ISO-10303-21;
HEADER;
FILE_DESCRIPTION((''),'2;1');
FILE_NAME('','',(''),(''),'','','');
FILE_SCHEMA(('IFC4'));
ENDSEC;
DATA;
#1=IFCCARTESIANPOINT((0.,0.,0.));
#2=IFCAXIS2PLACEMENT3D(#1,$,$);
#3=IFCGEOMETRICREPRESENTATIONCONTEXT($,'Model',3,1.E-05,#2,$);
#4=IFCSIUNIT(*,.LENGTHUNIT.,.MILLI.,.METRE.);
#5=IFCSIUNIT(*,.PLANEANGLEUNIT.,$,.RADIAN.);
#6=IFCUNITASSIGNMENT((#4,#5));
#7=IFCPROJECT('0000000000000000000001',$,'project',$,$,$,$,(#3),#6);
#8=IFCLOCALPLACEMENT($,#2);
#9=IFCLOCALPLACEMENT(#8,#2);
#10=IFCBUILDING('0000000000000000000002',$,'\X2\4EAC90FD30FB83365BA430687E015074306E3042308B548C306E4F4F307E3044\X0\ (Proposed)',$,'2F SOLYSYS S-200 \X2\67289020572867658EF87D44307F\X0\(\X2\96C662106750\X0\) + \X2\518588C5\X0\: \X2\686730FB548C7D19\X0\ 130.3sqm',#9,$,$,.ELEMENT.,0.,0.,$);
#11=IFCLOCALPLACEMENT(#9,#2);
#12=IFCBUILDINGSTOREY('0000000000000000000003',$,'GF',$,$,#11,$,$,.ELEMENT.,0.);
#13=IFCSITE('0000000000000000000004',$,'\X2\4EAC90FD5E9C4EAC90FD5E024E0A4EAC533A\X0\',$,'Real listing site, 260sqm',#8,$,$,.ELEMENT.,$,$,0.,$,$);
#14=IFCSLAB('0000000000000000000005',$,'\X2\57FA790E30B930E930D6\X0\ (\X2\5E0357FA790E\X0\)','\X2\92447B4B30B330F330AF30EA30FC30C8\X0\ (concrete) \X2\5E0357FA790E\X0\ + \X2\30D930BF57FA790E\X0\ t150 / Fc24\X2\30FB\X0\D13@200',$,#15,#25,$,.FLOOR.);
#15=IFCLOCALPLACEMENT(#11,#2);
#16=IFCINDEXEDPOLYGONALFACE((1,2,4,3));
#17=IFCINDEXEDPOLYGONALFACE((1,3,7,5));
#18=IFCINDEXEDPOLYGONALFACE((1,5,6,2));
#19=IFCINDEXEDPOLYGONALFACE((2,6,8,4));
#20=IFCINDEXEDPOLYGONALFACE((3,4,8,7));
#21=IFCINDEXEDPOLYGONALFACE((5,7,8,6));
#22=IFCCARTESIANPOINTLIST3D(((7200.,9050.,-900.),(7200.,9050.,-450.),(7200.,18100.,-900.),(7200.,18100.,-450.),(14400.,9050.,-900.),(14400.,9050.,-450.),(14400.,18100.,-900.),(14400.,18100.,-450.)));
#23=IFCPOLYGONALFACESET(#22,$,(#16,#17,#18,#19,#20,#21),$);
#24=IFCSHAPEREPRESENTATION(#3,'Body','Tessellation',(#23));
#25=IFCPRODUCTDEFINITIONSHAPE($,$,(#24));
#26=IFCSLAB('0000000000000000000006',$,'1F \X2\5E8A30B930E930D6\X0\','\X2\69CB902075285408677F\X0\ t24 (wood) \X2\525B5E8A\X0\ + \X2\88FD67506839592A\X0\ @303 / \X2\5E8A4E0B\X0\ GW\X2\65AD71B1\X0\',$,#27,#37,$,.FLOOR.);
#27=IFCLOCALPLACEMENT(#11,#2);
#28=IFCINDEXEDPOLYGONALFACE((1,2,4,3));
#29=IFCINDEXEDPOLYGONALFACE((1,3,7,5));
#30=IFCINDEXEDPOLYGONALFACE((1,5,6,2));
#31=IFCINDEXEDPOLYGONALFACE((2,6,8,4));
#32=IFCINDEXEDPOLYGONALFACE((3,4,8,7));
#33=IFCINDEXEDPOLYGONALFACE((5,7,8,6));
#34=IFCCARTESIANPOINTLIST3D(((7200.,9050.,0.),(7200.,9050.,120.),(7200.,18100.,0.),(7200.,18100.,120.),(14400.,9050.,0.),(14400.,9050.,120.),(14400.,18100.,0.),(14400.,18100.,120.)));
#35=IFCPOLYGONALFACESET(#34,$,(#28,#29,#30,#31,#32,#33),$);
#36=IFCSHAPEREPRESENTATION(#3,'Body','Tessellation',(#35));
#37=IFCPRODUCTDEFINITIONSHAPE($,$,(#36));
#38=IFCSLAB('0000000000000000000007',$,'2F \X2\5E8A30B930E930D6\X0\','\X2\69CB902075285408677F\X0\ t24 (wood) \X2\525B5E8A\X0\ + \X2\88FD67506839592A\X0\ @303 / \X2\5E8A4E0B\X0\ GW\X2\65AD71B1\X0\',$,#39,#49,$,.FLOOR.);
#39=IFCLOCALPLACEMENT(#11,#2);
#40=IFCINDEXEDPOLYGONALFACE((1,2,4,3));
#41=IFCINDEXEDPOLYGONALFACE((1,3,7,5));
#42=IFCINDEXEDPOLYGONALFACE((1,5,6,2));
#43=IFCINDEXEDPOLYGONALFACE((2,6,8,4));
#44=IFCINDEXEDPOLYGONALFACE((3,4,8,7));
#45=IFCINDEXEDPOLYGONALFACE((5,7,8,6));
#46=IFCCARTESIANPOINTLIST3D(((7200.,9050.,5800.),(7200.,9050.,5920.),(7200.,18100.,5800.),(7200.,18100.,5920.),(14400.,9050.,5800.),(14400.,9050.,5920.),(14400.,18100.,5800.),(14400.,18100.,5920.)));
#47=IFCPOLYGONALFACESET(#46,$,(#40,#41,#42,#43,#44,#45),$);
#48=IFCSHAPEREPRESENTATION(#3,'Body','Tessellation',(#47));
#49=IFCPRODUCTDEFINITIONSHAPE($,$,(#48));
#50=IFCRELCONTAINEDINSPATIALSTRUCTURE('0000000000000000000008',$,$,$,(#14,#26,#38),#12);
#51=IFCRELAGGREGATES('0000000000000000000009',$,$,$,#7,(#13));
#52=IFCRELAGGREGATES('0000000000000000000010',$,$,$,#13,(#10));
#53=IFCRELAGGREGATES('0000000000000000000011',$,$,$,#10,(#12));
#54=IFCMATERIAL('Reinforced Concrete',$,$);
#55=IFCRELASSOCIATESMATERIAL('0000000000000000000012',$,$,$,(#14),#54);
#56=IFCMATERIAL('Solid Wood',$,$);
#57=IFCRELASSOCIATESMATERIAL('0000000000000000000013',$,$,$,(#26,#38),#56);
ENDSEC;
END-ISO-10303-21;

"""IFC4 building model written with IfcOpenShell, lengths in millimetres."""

from ifc_helpers import new_model, si_unit, frame, frame_2d, origin, place, context, project, spatial, rectangle, extrude, material, element, save


model = new_model("IFC4")

# Units and contexts
model_context = context("Model", 3, precision=1e-05, world=origin())
ifc_project = project(units=[si_unit("LENGTHUNIT", "METRE", prefix="MILLI"), si_unit("PLANEANGLEUNIT", "RADIAN")], contexts=[model_context])

# Site, building, storey
site_placement = place(None, origin())
site = spatial("IfcSite", under=ifc_project, at=site_placement, Name="京都府京都市上京区", ObjectType="Real listing site, 260sqm", CompositionType="ELEMENT", RefElevation=0.0)
building_placement = place(site_placement, origin())
building = spatial("IfcBuilding", under=site, at=building_placement, Name="京都・茶室と縁側のある和の住まい (Proposed)", ObjectType="2F SOLYSYS S-200 木造在来軸組み(集成材) + 内装: 桧・和紙 130.3sqm", CompositionType="ELEMENT", ElevationOfRefHeight=0.0, ElevationOfTerrain=0.0)
storey_placement = place(building_placement, origin())
storey = spatial("IfcBuildingStorey", under=building, at=storey_placement, Name="GF", CompositionType="ELEMENT", Elevation=0.0)

# Shared definitions
ifc_material_1 = material(Name="Solid Wood")

# Slabs
ifc_material_2 = material(Name="Reinforced Concrete")
slab_1_placement = place(storey_placement, frame((3600.0, 4525.0, -450.0)))
element("IfcSlab", 1, at=slab_1_placement, inside=storey, material=ifc_material_2, Name="基礎スラブ (布基礎)", Description="鉄筋コンクリート (concrete) 布基礎 + ベタ基礎 t150 / Fc24・D13@200", PredefinedType="FLOOR", context=model_context, shape_type="SweptSolid", body=[
    extrude(rectangle(XDim=7200.0, YDim=9050.0, at=frame_2d((3600.0, 4525.0))), frame((3600.0, 4525.0, -450.0)), (0.0, 0.0, 1.0), 450.0),
])
slab_2_placement = place(storey_placement, frame((3600.0, 4525.0, 0.0)))
element("IfcSlab", 2, at=slab_2_placement, inside=storey, material=ifc_material_1, Name="1F 床スラブ", Description="構造用合板 t24 (wood) 剛床 + 製材根太 @303 / 床下 GW断熱", PredefinedType="FLOOR", context=model_context, shape_type="SweptSolid", body=[
    extrude(rectangle(XDim=7200.0, YDim=9050.0, at=frame_2d((3600.0, 4525.0))), frame((3600.0, 4525.0, 0.0)), (0.0, 0.0, 1.0), 120.0),
])
slab_3_placement = place(storey_placement, frame((3600.0, 4525.0, 2900.0)))
element("IfcSlab", 3, at=slab_3_placement, inside=storey, material=ifc_material_1, Name="2F 床スラブ", Description="構造用合板 t24 (wood) 剛床 + 製材根太 @303 / 床下 GW断熱", PredefinedType="FLOOR", context=model_context, shape_type="SweptSolid", body=[
    extrude(rectangle(XDim=7200.0, YDim=9050.0, at=frame_2d((3600.0, 4525.0))), frame((3600.0, 4525.0, 2900.0)), (0.0, 0.0, 1.0), 120.0),
])

save(model, "model.ifc")
